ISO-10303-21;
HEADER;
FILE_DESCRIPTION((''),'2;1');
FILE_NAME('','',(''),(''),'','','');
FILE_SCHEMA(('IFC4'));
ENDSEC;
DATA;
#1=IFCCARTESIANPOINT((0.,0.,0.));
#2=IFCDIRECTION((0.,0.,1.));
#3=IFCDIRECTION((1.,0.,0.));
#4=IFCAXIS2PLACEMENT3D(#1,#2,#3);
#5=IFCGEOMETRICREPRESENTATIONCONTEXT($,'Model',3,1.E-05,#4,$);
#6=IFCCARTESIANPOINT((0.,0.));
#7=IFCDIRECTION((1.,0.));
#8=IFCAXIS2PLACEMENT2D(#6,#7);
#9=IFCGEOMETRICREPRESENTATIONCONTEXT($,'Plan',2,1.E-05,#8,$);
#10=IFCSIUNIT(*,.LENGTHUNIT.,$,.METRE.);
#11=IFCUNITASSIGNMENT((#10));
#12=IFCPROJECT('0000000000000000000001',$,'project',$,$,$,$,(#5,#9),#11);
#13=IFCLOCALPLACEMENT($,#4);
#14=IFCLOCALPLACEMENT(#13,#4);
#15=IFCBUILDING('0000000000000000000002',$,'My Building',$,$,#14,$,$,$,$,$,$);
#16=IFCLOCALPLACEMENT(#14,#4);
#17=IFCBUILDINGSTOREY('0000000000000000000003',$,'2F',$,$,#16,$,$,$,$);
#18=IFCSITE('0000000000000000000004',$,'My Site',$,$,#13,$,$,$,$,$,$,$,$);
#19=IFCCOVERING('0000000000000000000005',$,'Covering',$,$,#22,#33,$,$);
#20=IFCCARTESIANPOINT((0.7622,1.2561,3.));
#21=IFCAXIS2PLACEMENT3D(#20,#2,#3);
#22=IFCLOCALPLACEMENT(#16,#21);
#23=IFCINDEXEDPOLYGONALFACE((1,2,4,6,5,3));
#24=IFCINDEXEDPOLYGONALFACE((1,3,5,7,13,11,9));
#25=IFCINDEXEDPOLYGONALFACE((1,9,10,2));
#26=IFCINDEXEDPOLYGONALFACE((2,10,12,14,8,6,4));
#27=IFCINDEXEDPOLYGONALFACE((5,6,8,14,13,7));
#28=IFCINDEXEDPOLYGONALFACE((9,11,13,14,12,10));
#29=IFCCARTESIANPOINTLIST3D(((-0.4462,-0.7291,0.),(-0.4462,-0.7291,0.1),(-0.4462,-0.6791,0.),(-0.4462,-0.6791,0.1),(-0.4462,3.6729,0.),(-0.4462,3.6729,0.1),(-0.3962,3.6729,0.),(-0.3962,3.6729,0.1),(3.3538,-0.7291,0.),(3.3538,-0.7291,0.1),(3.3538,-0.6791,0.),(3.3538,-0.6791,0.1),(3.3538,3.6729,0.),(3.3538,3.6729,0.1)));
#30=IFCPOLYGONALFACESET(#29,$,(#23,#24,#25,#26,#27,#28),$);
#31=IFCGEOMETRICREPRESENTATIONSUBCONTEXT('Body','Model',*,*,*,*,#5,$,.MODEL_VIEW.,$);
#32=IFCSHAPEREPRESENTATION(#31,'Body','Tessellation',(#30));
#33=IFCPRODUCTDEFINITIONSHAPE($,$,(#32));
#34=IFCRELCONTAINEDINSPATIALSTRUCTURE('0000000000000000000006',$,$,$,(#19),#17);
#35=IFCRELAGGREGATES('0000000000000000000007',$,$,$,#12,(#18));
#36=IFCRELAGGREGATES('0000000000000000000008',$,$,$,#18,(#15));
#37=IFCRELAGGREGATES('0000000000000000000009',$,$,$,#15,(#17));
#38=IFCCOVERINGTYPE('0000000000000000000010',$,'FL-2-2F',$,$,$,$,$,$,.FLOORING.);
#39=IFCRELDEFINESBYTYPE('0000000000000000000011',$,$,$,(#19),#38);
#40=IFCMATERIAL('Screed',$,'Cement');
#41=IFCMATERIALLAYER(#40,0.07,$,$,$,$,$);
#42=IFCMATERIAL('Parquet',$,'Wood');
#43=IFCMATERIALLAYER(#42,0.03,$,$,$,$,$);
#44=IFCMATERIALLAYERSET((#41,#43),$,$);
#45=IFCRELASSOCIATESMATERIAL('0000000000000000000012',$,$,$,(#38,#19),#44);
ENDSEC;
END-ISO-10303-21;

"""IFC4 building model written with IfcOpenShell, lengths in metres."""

from ifc_helpers import new_model, si_unit, frame, origin_with_axes, origin_2d_with_axis, place, context, subcontext, project, spatial, line, indexed_curve, outline, extrude, material, layer, layer_set, layer_usage, type_object, element, save


model = new_model("IFC4")

# Units and contexts
model_context = context("Model", 3, precision=1e-05, world=origin_with_axes())
plan_context = context("Plan", 2, precision=1e-05, world=origin_2d_with_axis())
body_context_1 = subcontext(model_context, "Body", "Model", "MODEL_VIEW")
ifc_project = project(units=[si_unit("LENGTHUNIT", "METRE")], contexts=[model_context, plan_context])

# Site, building, storey
site_placement = place(None, origin_with_axes())
site = spatial("IfcSite", under=ifc_project, at=site_placement, Name="My Site")
building_placement = place(site_placement, origin_with_axes())
building = spatial("IfcBuilding", under=site, at=building_placement, Name="My Building")
storey_placement = place(building_placement, origin_with_axes())
storey = spatial("IfcBuildingStorey", under=building, at=storey_placement, Name="2F")

# Covering
ifc_material_1 = material(Name="Screed", Category="Cement")
ifc_layer_1 = layer(ifc_material_1, 0.07)
ifc_material_2 = material(Name="Parquet", Category="Wood")
ifc_layer_2 = layer(ifc_material_2, 0.03)
ifc_layer_set_1 = layer_set([ifc_layer_1, ifc_layer_2])
ifc_layer_usage_1 = layer_usage(ifc_layer_set_1, "AXIS3", "POSITIVE", 0.0)
covering_type = type_object("IfcCoveringType", Name="FL-2-2F", PredefinedType="FLOORING", material=ifc_layer_set_1)
covering_placement = place(storey_placement, frame((0.7622, 1.2561, 3.0), z_axis=(0.0, 0.0, 1.0), x_axis=(1.0, 0.0, 0.0)))
element("IfcCovering", 1, at=covering_placement, inside=storey, type_object=covering_type, material=ifc_layer_usage_1, Name="Covering", context=body_context_1, shape_type="SweptSolid", body=[
    extrude(outline(indexed_curve([(3.3538, 3.6729), (3.3538, -0.6791), (3.3538, -0.7291), (-0.4462, -0.7291), (-0.4462, -0.6791), (-0.4462, 3.6729), (-0.3962, 3.6729)], segments=[line(1, 2, 3, 4, 5, 6, 7, 1)])), origin_with_axes(), (0.0, 0.0, 1.0), 0.1),
])

save(model, "model.ifc")
